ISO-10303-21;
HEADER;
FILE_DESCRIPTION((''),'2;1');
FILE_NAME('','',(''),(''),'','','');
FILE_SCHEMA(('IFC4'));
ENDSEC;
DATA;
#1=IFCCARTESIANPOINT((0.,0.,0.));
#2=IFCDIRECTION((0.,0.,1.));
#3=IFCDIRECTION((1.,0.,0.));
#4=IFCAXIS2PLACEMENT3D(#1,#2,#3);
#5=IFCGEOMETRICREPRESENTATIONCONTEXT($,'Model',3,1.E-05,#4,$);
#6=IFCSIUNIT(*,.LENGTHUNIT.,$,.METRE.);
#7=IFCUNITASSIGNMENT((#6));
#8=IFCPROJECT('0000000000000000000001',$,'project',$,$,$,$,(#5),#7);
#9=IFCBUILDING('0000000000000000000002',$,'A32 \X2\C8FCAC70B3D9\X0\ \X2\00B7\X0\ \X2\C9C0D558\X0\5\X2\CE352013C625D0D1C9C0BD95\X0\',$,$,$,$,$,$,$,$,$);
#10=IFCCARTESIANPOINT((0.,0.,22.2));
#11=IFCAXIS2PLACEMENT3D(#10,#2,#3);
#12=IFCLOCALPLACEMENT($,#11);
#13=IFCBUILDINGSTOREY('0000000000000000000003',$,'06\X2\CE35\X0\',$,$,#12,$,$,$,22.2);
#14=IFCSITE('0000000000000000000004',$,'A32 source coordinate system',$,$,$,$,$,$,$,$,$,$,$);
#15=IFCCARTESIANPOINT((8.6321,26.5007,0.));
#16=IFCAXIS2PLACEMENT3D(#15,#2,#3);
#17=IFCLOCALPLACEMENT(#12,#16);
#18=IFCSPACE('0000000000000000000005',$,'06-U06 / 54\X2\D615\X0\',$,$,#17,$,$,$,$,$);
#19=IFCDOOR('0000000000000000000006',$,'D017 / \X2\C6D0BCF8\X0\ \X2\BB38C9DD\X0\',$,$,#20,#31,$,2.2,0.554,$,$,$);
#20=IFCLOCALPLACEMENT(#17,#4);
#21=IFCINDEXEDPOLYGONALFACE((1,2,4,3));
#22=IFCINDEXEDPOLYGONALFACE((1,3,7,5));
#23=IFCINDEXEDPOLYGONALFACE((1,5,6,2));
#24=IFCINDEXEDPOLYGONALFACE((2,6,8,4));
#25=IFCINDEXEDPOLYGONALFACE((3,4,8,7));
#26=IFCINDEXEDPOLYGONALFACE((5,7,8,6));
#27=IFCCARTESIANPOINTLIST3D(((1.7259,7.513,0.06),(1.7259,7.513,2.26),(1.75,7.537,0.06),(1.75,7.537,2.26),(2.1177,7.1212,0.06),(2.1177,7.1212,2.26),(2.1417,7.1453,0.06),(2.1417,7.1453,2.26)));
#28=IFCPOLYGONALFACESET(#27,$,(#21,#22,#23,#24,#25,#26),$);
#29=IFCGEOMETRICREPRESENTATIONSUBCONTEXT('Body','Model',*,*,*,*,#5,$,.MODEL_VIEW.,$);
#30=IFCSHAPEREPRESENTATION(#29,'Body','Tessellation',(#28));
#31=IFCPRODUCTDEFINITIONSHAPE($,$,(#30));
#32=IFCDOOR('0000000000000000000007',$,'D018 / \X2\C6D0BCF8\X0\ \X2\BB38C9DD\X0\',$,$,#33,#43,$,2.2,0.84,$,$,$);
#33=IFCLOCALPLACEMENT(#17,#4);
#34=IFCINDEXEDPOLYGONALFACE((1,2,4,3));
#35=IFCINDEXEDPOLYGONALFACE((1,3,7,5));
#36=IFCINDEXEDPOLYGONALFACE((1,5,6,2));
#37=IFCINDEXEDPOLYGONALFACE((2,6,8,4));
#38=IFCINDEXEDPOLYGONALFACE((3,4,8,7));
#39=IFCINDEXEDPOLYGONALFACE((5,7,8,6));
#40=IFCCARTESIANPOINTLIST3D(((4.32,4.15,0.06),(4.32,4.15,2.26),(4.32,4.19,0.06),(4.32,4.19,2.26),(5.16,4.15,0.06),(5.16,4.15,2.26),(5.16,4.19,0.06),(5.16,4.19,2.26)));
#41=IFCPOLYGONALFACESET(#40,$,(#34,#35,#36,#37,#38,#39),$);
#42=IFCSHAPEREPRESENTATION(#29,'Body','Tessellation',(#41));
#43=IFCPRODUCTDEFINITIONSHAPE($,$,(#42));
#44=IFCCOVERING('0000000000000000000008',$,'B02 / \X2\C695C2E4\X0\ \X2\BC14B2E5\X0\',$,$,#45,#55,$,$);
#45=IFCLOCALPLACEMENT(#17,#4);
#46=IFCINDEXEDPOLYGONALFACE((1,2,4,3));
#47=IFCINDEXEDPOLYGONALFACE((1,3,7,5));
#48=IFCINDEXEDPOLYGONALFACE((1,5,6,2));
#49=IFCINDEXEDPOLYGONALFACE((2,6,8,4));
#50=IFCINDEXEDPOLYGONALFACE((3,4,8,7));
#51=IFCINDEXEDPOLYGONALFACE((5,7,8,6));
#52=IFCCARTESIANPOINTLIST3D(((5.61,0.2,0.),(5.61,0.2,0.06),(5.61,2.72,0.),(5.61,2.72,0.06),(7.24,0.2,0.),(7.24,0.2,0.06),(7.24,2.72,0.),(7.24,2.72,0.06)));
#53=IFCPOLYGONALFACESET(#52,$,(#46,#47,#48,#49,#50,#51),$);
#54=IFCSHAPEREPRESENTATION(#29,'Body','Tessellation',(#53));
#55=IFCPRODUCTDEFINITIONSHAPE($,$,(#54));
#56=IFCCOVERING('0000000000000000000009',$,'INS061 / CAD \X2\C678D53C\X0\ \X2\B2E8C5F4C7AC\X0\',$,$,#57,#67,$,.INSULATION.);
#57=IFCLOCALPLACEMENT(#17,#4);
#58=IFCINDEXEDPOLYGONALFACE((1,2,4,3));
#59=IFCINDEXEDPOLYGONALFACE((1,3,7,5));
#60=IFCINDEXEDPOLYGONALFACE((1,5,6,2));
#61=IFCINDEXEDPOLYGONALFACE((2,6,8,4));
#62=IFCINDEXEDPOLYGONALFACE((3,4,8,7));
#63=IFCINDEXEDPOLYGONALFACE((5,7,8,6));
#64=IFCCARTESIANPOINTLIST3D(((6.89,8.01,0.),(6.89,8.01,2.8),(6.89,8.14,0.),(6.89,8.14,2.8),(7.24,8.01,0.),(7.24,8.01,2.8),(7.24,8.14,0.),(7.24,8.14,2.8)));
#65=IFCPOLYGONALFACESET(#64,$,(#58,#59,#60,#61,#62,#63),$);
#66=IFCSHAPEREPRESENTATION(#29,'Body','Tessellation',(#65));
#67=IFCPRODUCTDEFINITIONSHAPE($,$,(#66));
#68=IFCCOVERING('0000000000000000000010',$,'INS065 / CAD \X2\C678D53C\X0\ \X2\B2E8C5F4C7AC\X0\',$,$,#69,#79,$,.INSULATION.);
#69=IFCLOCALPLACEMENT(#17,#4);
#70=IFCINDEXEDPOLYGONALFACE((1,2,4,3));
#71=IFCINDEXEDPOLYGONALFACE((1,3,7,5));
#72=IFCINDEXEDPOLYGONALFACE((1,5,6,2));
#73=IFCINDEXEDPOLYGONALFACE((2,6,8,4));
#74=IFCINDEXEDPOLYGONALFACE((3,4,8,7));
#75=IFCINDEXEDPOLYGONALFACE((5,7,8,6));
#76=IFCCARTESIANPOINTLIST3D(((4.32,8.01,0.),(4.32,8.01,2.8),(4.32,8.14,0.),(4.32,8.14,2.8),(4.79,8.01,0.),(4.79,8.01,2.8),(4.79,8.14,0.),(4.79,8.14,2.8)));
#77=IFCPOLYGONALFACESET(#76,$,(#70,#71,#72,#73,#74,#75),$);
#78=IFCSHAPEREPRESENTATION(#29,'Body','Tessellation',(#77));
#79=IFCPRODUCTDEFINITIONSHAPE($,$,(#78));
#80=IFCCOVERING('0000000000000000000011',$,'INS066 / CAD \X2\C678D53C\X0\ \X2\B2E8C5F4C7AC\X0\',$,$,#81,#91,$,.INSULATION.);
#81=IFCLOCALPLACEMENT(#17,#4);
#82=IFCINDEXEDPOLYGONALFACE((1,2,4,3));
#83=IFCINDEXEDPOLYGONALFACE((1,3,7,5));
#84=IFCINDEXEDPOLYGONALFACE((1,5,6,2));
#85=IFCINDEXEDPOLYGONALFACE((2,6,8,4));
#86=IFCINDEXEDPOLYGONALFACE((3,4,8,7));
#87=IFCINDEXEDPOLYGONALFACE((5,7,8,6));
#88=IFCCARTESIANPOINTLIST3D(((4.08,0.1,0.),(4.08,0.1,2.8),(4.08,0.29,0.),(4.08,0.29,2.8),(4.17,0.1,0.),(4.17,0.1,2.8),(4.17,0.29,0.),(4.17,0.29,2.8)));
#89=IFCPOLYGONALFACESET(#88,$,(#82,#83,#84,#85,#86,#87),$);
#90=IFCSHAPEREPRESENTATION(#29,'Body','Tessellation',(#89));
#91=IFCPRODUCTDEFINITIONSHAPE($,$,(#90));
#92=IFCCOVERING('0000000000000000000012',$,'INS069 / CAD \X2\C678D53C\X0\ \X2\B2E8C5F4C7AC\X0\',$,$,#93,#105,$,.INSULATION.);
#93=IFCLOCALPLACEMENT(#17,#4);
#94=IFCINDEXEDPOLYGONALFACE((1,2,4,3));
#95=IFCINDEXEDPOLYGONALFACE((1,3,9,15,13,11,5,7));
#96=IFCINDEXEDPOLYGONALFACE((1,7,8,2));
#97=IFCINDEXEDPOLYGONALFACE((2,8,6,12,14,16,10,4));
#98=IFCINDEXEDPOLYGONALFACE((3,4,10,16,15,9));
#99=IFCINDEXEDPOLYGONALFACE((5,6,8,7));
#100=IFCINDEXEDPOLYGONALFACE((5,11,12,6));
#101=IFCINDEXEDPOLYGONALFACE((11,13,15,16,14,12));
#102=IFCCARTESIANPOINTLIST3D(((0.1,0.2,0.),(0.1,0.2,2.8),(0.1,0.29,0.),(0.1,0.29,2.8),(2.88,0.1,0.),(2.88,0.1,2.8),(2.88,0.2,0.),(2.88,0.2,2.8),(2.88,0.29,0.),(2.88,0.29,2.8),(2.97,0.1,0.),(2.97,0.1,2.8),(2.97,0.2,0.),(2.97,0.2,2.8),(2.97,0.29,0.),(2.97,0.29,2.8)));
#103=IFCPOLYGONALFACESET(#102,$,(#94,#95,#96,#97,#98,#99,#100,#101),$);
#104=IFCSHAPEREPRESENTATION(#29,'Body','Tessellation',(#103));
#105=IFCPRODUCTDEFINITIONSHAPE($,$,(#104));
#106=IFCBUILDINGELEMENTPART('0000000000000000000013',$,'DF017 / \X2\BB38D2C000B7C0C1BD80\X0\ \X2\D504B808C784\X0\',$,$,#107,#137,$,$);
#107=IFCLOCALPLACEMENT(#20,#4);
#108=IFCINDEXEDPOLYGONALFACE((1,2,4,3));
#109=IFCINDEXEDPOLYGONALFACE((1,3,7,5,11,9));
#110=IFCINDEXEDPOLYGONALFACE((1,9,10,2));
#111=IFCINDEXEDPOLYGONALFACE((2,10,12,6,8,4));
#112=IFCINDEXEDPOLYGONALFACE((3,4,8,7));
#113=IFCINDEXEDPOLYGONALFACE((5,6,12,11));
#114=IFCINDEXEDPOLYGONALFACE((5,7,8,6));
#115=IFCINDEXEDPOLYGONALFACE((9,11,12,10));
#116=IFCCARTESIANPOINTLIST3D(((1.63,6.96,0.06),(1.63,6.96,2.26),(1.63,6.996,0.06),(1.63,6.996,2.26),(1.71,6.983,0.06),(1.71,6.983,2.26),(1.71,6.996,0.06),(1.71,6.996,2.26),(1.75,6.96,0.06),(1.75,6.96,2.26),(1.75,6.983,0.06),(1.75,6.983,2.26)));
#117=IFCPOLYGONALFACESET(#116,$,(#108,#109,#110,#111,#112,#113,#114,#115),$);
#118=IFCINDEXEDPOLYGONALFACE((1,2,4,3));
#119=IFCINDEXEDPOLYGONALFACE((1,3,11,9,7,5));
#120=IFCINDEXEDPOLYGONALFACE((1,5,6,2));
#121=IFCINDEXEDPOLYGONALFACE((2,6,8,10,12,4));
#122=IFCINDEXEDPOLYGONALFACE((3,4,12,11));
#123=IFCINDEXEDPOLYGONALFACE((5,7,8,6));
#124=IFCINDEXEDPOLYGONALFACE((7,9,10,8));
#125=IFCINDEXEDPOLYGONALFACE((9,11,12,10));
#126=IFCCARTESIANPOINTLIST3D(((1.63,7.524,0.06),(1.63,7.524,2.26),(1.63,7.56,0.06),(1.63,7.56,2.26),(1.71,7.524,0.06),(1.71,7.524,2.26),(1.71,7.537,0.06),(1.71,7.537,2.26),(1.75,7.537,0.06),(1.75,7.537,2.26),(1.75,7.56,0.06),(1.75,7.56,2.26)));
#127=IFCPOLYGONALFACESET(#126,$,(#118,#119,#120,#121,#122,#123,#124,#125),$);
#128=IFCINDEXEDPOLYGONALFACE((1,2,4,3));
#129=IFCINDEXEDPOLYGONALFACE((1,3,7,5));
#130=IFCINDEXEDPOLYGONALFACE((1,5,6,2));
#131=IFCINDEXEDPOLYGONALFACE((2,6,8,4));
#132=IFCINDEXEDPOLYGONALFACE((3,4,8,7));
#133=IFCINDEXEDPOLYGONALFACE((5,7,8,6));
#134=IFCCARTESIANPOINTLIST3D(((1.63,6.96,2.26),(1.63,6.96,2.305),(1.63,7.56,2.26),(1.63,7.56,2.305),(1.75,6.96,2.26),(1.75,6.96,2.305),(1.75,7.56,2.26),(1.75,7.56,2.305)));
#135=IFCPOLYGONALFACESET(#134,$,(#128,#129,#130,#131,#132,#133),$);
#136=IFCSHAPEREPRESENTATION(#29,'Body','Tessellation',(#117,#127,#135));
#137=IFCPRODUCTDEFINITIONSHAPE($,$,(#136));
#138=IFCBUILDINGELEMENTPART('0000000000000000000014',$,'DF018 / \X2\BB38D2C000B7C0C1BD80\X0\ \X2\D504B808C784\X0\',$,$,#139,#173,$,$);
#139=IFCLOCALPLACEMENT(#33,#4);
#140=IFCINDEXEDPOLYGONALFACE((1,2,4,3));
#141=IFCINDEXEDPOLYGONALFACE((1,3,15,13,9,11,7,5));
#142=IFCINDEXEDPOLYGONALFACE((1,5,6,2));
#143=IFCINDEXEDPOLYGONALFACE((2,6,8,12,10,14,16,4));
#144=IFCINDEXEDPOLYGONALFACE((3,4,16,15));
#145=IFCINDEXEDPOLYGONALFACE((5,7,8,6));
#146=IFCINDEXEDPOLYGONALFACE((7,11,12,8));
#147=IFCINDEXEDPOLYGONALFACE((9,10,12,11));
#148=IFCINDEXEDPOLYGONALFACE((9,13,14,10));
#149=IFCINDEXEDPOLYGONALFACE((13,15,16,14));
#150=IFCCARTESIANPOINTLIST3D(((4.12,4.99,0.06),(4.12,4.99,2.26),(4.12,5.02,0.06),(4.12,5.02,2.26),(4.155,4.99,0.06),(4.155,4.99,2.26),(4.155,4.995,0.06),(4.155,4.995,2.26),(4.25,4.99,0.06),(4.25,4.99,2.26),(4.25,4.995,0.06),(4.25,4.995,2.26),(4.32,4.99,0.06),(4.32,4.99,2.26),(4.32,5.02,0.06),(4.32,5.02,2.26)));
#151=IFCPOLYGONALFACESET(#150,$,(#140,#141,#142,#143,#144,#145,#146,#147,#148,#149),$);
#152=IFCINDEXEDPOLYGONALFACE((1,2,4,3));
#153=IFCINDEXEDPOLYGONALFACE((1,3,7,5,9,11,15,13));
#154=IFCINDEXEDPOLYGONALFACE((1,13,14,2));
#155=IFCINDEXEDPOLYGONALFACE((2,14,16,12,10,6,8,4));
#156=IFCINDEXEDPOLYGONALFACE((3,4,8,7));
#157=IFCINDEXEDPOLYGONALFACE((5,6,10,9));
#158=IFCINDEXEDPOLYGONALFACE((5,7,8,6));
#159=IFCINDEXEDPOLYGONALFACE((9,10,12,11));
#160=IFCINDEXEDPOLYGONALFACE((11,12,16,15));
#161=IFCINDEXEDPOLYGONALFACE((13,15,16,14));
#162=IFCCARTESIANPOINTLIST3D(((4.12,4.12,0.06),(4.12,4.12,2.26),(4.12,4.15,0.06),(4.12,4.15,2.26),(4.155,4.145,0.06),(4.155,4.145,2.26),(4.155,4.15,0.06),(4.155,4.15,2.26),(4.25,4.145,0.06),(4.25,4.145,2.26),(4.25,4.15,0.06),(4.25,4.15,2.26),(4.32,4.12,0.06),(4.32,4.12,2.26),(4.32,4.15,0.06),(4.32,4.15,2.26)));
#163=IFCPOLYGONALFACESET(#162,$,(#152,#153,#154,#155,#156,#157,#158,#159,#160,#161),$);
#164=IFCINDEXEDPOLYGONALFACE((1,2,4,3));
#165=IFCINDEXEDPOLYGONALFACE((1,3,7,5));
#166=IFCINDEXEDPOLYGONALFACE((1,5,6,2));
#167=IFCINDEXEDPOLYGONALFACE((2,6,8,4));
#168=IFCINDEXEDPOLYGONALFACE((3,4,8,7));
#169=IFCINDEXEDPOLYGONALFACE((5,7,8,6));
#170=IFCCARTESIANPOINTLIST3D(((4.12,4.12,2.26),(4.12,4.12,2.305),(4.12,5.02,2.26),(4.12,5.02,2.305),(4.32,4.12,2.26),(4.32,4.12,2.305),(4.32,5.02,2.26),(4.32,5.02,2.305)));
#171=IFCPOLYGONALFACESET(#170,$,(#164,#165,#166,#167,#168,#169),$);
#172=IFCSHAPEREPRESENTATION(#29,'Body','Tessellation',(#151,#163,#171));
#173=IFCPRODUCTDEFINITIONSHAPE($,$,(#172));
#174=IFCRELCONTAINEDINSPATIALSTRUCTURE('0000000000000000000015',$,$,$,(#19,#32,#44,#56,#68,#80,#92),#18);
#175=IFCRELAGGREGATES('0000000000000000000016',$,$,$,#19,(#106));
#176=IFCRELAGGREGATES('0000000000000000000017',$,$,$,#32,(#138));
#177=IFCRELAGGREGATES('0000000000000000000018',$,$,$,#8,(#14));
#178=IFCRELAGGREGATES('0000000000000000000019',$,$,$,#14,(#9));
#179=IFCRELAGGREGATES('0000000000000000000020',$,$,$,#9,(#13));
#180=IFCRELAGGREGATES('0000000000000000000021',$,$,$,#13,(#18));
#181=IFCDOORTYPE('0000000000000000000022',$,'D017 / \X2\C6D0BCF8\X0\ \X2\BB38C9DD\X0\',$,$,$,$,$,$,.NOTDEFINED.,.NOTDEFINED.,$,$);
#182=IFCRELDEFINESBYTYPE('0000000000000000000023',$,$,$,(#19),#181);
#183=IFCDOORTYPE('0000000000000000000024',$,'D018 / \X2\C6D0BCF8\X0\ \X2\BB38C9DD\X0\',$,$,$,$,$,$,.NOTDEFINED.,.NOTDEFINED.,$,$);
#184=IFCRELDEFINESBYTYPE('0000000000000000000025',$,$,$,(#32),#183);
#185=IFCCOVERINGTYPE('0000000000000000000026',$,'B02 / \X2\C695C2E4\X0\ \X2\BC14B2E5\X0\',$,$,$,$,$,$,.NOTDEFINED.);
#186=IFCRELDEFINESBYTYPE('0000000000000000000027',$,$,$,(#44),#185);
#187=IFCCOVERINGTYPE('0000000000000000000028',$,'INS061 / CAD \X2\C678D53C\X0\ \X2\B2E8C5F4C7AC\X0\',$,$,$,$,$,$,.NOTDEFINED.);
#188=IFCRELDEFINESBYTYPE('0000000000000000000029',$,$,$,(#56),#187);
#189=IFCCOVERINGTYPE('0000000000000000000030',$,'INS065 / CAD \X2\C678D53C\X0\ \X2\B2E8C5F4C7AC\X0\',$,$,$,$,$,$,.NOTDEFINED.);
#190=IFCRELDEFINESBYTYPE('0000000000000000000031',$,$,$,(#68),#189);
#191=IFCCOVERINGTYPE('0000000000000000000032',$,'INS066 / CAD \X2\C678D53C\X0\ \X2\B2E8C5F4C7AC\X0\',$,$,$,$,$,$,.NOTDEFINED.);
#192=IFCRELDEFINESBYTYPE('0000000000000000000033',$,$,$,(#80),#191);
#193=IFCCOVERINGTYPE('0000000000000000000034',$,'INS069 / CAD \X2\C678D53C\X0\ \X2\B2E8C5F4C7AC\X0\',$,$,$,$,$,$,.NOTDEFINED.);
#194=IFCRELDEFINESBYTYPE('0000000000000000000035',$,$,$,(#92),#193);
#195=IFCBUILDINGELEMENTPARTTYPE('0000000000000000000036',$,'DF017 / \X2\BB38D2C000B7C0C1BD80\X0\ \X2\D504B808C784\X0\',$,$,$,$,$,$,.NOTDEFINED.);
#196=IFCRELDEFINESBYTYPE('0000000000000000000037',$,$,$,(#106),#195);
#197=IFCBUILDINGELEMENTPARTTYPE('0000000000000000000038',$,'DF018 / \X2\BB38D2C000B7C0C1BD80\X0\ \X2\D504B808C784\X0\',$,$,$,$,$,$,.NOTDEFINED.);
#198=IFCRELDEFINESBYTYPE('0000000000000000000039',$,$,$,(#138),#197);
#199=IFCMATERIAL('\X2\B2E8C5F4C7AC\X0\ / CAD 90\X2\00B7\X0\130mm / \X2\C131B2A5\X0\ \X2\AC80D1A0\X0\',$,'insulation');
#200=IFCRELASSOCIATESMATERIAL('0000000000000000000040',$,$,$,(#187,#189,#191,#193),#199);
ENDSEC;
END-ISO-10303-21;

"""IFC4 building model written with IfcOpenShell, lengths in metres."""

from ifc_helpers import new_model, si_unit, frame, origin, origin_with_axes, place, context, subcontext, project, spatial, polyline, outline, extrude, source, transform, mapped, material, type_object, type_shapes, element, aggregate, save


model = new_model("IFC4")

# Units and contexts
model_context = context("Model", 3, precision=1e-05, world=origin_with_axes())
body_context = subcontext(model_context, "Body", "Model", "MODEL_VIEW")
ifc_project = project(units=[si_unit("LENGTHUNIT", "METRE")], contexts=[model_context])

# Site, building, storey, space
storey_placement = place(None, frame((0.0, 0.0, 22.2), z_axis=(0.0, 0.0, 1.0), x_axis=(1.0, 0.0, 0.0)))
space_1_placement = place(storey_placement, frame((8.6321, 26.5007, 0.0), z_axis=(0.0, 0.0, 1.0), x_axis=(1.0, 0.0, 0.0)))
site = spatial("IfcSite", under=ifc_project, Name="A32 source coordinate system")
building = spatial("IfcBuilding", under=site, Name="A32 주거동 · 지하5층–옥탑지붕")
storey = spatial("IfcBuildingStorey", under=building, at=storey_placement, Name="06층", Elevation=22.2)
space_1 = spatial("IfcSpace", under=storey, at=space_1_placement, Name="06-U06 / 54형")

# Doors
door_type_1 = type_object("IfcDoorType", Name="D017 / 원본 문짝", OperationType="NOTDEFINED", PredefinedType="NOTDEFINED")
shared_shape_1 = source(origin(), body_context, "Body", "SweptSolid", [
    extrude(outline(polyline([(1.75, 7.537), (2.1417, 7.1453), (2.1177, 7.1212), (1.7259, 7.513), (1.75, 7.537)])), frame((0.0, 0.0, 0.06)), (0.0, 0.0, 1.0), 2.2),
])
type_shapes(door_type_1, [shared_shape_1])
door_1_placement = place(space_1_placement, origin_with_axes())
door_1 = element("IfcDoor", 1, at=door_1_placement, inside=space_1, type_object=door_type_1, Name="D017 / 원본 문짝", OverallHeight=2.2, OverallWidth=0.554, context=body_context, shape_type="MappedRepresentation", body=[
    mapped(shared_shape_1, transform((0.0, 0.0, 0.0), scale=1.0)),
])
door_type_2 = type_object("IfcDoorType", Name="D018 / 원본 문짝", OperationType="NOTDEFINED", PredefinedType="NOTDEFINED")
shared_shape_2 = source(origin(), body_context, "Body", "SweptSolid", [
    extrude(outline(polyline([(5.16, 4.19), (5.16, 4.15), (4.32, 4.15), (4.32, 4.19), (5.16, 4.19)])), frame((0.0, 0.0, 0.06)), (0.0, 0.0, 1.0), 2.2),
])
type_shapes(door_type_2, [shared_shape_2])
door_2_placement = place(space_1_placement, origin_with_axes())
door_2 = element("IfcDoor", 2, at=door_2_placement, inside=space_1, type_object=door_type_2, Name="D018 / 원본 문짝", OverallHeight=2.2, OverallWidth=0.84, context=body_context, shape_type="MappedRepresentation", body=[
    mapped(shared_shape_2, transform((0.0, 0.0, 0.0), scale=1.0)),
])

# Coverings
covering_type_1 = type_object("IfcCoveringType", Name="B02 / 욕실 바닥", PredefinedType="NOTDEFINED")
shared_shape_3 = source(origin(), body_context, "Body", "SweptSolid", [
    extrude(outline(polyline([(5.61, 2.72), (7.24, 2.72), (7.24, 0.2), (5.61, 0.2), (5.61, 2.72)])), origin(), (0.0, 0.0, 1.0), 0.06),
])
type_shapes(covering_type_1, [shared_shape_3])
covering_1_placement = place(space_1_placement, origin_with_axes())
element("IfcCovering", 3, at=covering_1_placement, inside=space_1, type_object=covering_type_1, Name="B02 / 욕실 바닥", context=body_context, shape_type="MappedRepresentation", body=[
    mapped(shared_shape_3, transform((0.0, 0.0, 0.0), scale=1.0)),
])
ifc_material = material(Name="단열재 / CAD 90·130mm / 성능 검토", Category="insulation")
covering_type_2 = type_object("IfcCoveringType", Name="INS061 / CAD 외피 단열재", PredefinedType="NOTDEFINED", material=ifc_material)
shared_shape_4 = source(origin(), body_context, "Body", "SweptSolid", [
    extrude(outline(polyline([(6.89, 8.01), (6.89, 8.14), (7.24, 8.14), (7.24, 8.01), (6.89, 8.01)])), origin(), (0.0, 0.0, 1.0), 2.8),
])
type_shapes(covering_type_2, [shared_shape_4])
covering_2_placement = place(space_1_placement, origin_with_axes())
element("IfcCovering", 4, at=covering_2_placement, inside=space_1, type_object=covering_type_2, Name="INS061 / CAD 외피 단열재", PredefinedType="INSULATION", context=body_context, shape_type="MappedRepresentation", body=[
    mapped(shared_shape_4, transform((0.0, 0.0, 0.0), scale=1.0)),
])
covering_type_3 = type_object("IfcCoveringType", Name="INS065 / CAD 외피 단열재", PredefinedType="NOTDEFINED", material=ifc_material)
shared_shape_5 = source(origin(), body_context, "Body", "SweptSolid", [
    extrude(outline(polyline([(4.32, 8.01), (4.32, 8.14), (4.79, 8.14), (4.79, 8.01), (4.32, 8.01)])), origin(), (0.0, 0.0, 1.0), 2.8),
])
type_shapes(covering_type_3, [shared_shape_5])
covering_3_placement = place(space_1_placement, origin_with_axes())
element("IfcCovering", 5, at=covering_3_placement, inside=space_1, type_object=covering_type_3, Name="INS065 / CAD 외피 단열재", PredefinedType="INSULATION", context=body_context, shape_type="MappedRepresentation", body=[
    mapped(shared_shape_5, transform((0.0, 0.0, 0.0), scale=1.0)),
])
covering_type_4 = type_object("IfcCoveringType", Name="INS066 / CAD 외피 단열재", PredefinedType="NOTDEFINED", material=ifc_material)
shared_shape_6 = source(origin(), body_context, "Body", "SweptSolid", [
    extrude(outline(polyline([(4.08, 0.29), (4.17, 0.29), (4.17, 0.1), (4.08, 0.1), (4.08, 0.29)])), origin(), (0.0, 0.0, 1.0), 2.8),
])
type_shapes(covering_type_4, [shared_shape_6])
covering_4_placement = place(space_1_placement, origin_with_axes())
element("IfcCovering", 6, at=covering_4_placement, inside=space_1, type_object=covering_type_4, Name="INS066 / CAD 외피 단열재", PredefinedType="INSULATION", context=body_context, shape_type="MappedRepresentation", body=[
    mapped(shared_shape_6, transform((0.0, 0.0, 0.0), scale=1.0)),
])
covering_type_5 = type_object("IfcCoveringType", Name="INS069 / CAD 외피 단열재", PredefinedType="NOTDEFINED", material=ifc_material)
shared_shape_7 = source(origin(), body_context, "Body", "SweptSolid", [
    extrude(outline(polyline([(2.97, 0.1), (2.88, 0.1), (2.88, 0.2), (0.1, 0.2), (0.1, 0.29), (2.88, 0.29), (2.97, 0.29), (2.97, 0.2), (2.97, 0.1)])), origin(), (0.0, 0.0, 1.0), 2.8),
])
type_shapes(covering_type_5, [shared_shape_7])
covering_5_placement = place(space_1_placement, origin_with_axes())
element("IfcCovering", 7, at=covering_5_placement, inside=space_1, type_object=covering_type_5, Name="INS069 / CAD 외피 단열재", PredefinedType="INSULATION", context=body_context, shape_type="MappedRepresentation", body=[
    mapped(shared_shape_7, transform((0.0, 0.0, 0.0), scale=1.0)),
])

# Building element parts
building_element_part_type_1 = type_object("IfcBuildingElementPartType", Name="DF017 / 문틀·상부 프레임", PredefinedType="NOTDEFINED")
shared_shape_8 = source(origin(), body_context, "Body", "SweptSolid", [
    extrude(outline(polyline([(1.63, 6.996), (1.71, 6.996), (1.71, 6.983), (1.75, 6.983), (1.75, 6.96), (1.63, 6.96), (1.63, 6.996)])), frame((0.0, 0.0, 0.06)), (0.0, 0.0, 1.0), 2.2),
    extrude(outline(polyline([(1.75, 7.56), (1.75, 7.537), (1.71, 7.537), (1.71, 7.524), (1.63, 7.524), (1.63, 7.56), (1.75, 7.56)])), frame((0.0, 0.0, 0.06)), (0.0, 0.0, 1.0), 2.2),
    extrude(outline(polyline([(1.63, 6.96), (1.63, 7.56), (1.75, 7.56), (1.75, 6.96), (1.63, 6.96)])), frame((0.0, 0.0, 2.26)), (0.0, 0.0, 1.0), 0.045),
])
type_shapes(building_element_part_type_1, [shared_shape_8])
building_element_part_1_placement = place(door_1_placement, origin_with_axes())
building_element_part_1 = element("IfcBuildingElementPart", 8, at=building_element_part_1_placement, type_object=building_element_part_type_1, Name="DF017 / 문틀·상부 프레임", context=body_context, shape_type="MappedRepresentation", body=[
    mapped(shared_shape_8, transform((0.0, 0.0, 0.0), scale=1.0)),
])
aggregate(door_1, [building_element_part_1])
building_element_part_type_2 = type_object("IfcBuildingElementPartType", Name="DF018 / 문틀·상부 프레임", PredefinedType="NOTDEFINED")
shared_shape_9 = source(origin(), body_context, "Body", "SweptSolid", [
    extrude(outline(polyline([(4.32, 4.99), (4.25, 4.99), (4.25, 4.995), (4.155, 4.995), (4.155, 4.99), (4.12, 4.99), (4.12, 5.02), (4.32, 5.02), (4.32, 4.99)])), frame((0.0, 0.0, 0.06)), (0.0, 0.0, 1.0), 2.2),
    extrude(outline(polyline([(4.12, 4.12), (4.12, 4.15), (4.155, 4.15), (4.155, 4.145), (4.25, 4.145), (4.25, 4.15), (4.32, 4.15), (4.32, 4.12), (4.12, 4.12)])), frame((0.0, 0.0, 0.06)), (0.0, 0.0, 1.0), 2.2),
    extrude(outline(polyline([(4.12, 4.12), (4.12, 5.02), (4.32, 5.02), (4.32, 4.12), (4.12, 4.12)])), frame((0.0, 0.0, 2.26)), (0.0, 0.0, 1.0), 0.045),
])
type_shapes(building_element_part_type_2, [shared_shape_9])
building_element_part_2_placement = place(door_2_placement, origin_with_axes())
building_element_part_2 = element("IfcBuildingElementPart", 9, at=building_element_part_2_placement, type_object=building_element_part_type_2, Name="DF018 / 문틀·상부 프레임", context=body_context, shape_type="MappedRepresentation", body=[
    mapped(shared_shape_9, transform((0.0, 0.0, 0.0), scale=1.0)),
])
aggregate(door_2, [building_element_part_2])

save(model, "model.ifc")
